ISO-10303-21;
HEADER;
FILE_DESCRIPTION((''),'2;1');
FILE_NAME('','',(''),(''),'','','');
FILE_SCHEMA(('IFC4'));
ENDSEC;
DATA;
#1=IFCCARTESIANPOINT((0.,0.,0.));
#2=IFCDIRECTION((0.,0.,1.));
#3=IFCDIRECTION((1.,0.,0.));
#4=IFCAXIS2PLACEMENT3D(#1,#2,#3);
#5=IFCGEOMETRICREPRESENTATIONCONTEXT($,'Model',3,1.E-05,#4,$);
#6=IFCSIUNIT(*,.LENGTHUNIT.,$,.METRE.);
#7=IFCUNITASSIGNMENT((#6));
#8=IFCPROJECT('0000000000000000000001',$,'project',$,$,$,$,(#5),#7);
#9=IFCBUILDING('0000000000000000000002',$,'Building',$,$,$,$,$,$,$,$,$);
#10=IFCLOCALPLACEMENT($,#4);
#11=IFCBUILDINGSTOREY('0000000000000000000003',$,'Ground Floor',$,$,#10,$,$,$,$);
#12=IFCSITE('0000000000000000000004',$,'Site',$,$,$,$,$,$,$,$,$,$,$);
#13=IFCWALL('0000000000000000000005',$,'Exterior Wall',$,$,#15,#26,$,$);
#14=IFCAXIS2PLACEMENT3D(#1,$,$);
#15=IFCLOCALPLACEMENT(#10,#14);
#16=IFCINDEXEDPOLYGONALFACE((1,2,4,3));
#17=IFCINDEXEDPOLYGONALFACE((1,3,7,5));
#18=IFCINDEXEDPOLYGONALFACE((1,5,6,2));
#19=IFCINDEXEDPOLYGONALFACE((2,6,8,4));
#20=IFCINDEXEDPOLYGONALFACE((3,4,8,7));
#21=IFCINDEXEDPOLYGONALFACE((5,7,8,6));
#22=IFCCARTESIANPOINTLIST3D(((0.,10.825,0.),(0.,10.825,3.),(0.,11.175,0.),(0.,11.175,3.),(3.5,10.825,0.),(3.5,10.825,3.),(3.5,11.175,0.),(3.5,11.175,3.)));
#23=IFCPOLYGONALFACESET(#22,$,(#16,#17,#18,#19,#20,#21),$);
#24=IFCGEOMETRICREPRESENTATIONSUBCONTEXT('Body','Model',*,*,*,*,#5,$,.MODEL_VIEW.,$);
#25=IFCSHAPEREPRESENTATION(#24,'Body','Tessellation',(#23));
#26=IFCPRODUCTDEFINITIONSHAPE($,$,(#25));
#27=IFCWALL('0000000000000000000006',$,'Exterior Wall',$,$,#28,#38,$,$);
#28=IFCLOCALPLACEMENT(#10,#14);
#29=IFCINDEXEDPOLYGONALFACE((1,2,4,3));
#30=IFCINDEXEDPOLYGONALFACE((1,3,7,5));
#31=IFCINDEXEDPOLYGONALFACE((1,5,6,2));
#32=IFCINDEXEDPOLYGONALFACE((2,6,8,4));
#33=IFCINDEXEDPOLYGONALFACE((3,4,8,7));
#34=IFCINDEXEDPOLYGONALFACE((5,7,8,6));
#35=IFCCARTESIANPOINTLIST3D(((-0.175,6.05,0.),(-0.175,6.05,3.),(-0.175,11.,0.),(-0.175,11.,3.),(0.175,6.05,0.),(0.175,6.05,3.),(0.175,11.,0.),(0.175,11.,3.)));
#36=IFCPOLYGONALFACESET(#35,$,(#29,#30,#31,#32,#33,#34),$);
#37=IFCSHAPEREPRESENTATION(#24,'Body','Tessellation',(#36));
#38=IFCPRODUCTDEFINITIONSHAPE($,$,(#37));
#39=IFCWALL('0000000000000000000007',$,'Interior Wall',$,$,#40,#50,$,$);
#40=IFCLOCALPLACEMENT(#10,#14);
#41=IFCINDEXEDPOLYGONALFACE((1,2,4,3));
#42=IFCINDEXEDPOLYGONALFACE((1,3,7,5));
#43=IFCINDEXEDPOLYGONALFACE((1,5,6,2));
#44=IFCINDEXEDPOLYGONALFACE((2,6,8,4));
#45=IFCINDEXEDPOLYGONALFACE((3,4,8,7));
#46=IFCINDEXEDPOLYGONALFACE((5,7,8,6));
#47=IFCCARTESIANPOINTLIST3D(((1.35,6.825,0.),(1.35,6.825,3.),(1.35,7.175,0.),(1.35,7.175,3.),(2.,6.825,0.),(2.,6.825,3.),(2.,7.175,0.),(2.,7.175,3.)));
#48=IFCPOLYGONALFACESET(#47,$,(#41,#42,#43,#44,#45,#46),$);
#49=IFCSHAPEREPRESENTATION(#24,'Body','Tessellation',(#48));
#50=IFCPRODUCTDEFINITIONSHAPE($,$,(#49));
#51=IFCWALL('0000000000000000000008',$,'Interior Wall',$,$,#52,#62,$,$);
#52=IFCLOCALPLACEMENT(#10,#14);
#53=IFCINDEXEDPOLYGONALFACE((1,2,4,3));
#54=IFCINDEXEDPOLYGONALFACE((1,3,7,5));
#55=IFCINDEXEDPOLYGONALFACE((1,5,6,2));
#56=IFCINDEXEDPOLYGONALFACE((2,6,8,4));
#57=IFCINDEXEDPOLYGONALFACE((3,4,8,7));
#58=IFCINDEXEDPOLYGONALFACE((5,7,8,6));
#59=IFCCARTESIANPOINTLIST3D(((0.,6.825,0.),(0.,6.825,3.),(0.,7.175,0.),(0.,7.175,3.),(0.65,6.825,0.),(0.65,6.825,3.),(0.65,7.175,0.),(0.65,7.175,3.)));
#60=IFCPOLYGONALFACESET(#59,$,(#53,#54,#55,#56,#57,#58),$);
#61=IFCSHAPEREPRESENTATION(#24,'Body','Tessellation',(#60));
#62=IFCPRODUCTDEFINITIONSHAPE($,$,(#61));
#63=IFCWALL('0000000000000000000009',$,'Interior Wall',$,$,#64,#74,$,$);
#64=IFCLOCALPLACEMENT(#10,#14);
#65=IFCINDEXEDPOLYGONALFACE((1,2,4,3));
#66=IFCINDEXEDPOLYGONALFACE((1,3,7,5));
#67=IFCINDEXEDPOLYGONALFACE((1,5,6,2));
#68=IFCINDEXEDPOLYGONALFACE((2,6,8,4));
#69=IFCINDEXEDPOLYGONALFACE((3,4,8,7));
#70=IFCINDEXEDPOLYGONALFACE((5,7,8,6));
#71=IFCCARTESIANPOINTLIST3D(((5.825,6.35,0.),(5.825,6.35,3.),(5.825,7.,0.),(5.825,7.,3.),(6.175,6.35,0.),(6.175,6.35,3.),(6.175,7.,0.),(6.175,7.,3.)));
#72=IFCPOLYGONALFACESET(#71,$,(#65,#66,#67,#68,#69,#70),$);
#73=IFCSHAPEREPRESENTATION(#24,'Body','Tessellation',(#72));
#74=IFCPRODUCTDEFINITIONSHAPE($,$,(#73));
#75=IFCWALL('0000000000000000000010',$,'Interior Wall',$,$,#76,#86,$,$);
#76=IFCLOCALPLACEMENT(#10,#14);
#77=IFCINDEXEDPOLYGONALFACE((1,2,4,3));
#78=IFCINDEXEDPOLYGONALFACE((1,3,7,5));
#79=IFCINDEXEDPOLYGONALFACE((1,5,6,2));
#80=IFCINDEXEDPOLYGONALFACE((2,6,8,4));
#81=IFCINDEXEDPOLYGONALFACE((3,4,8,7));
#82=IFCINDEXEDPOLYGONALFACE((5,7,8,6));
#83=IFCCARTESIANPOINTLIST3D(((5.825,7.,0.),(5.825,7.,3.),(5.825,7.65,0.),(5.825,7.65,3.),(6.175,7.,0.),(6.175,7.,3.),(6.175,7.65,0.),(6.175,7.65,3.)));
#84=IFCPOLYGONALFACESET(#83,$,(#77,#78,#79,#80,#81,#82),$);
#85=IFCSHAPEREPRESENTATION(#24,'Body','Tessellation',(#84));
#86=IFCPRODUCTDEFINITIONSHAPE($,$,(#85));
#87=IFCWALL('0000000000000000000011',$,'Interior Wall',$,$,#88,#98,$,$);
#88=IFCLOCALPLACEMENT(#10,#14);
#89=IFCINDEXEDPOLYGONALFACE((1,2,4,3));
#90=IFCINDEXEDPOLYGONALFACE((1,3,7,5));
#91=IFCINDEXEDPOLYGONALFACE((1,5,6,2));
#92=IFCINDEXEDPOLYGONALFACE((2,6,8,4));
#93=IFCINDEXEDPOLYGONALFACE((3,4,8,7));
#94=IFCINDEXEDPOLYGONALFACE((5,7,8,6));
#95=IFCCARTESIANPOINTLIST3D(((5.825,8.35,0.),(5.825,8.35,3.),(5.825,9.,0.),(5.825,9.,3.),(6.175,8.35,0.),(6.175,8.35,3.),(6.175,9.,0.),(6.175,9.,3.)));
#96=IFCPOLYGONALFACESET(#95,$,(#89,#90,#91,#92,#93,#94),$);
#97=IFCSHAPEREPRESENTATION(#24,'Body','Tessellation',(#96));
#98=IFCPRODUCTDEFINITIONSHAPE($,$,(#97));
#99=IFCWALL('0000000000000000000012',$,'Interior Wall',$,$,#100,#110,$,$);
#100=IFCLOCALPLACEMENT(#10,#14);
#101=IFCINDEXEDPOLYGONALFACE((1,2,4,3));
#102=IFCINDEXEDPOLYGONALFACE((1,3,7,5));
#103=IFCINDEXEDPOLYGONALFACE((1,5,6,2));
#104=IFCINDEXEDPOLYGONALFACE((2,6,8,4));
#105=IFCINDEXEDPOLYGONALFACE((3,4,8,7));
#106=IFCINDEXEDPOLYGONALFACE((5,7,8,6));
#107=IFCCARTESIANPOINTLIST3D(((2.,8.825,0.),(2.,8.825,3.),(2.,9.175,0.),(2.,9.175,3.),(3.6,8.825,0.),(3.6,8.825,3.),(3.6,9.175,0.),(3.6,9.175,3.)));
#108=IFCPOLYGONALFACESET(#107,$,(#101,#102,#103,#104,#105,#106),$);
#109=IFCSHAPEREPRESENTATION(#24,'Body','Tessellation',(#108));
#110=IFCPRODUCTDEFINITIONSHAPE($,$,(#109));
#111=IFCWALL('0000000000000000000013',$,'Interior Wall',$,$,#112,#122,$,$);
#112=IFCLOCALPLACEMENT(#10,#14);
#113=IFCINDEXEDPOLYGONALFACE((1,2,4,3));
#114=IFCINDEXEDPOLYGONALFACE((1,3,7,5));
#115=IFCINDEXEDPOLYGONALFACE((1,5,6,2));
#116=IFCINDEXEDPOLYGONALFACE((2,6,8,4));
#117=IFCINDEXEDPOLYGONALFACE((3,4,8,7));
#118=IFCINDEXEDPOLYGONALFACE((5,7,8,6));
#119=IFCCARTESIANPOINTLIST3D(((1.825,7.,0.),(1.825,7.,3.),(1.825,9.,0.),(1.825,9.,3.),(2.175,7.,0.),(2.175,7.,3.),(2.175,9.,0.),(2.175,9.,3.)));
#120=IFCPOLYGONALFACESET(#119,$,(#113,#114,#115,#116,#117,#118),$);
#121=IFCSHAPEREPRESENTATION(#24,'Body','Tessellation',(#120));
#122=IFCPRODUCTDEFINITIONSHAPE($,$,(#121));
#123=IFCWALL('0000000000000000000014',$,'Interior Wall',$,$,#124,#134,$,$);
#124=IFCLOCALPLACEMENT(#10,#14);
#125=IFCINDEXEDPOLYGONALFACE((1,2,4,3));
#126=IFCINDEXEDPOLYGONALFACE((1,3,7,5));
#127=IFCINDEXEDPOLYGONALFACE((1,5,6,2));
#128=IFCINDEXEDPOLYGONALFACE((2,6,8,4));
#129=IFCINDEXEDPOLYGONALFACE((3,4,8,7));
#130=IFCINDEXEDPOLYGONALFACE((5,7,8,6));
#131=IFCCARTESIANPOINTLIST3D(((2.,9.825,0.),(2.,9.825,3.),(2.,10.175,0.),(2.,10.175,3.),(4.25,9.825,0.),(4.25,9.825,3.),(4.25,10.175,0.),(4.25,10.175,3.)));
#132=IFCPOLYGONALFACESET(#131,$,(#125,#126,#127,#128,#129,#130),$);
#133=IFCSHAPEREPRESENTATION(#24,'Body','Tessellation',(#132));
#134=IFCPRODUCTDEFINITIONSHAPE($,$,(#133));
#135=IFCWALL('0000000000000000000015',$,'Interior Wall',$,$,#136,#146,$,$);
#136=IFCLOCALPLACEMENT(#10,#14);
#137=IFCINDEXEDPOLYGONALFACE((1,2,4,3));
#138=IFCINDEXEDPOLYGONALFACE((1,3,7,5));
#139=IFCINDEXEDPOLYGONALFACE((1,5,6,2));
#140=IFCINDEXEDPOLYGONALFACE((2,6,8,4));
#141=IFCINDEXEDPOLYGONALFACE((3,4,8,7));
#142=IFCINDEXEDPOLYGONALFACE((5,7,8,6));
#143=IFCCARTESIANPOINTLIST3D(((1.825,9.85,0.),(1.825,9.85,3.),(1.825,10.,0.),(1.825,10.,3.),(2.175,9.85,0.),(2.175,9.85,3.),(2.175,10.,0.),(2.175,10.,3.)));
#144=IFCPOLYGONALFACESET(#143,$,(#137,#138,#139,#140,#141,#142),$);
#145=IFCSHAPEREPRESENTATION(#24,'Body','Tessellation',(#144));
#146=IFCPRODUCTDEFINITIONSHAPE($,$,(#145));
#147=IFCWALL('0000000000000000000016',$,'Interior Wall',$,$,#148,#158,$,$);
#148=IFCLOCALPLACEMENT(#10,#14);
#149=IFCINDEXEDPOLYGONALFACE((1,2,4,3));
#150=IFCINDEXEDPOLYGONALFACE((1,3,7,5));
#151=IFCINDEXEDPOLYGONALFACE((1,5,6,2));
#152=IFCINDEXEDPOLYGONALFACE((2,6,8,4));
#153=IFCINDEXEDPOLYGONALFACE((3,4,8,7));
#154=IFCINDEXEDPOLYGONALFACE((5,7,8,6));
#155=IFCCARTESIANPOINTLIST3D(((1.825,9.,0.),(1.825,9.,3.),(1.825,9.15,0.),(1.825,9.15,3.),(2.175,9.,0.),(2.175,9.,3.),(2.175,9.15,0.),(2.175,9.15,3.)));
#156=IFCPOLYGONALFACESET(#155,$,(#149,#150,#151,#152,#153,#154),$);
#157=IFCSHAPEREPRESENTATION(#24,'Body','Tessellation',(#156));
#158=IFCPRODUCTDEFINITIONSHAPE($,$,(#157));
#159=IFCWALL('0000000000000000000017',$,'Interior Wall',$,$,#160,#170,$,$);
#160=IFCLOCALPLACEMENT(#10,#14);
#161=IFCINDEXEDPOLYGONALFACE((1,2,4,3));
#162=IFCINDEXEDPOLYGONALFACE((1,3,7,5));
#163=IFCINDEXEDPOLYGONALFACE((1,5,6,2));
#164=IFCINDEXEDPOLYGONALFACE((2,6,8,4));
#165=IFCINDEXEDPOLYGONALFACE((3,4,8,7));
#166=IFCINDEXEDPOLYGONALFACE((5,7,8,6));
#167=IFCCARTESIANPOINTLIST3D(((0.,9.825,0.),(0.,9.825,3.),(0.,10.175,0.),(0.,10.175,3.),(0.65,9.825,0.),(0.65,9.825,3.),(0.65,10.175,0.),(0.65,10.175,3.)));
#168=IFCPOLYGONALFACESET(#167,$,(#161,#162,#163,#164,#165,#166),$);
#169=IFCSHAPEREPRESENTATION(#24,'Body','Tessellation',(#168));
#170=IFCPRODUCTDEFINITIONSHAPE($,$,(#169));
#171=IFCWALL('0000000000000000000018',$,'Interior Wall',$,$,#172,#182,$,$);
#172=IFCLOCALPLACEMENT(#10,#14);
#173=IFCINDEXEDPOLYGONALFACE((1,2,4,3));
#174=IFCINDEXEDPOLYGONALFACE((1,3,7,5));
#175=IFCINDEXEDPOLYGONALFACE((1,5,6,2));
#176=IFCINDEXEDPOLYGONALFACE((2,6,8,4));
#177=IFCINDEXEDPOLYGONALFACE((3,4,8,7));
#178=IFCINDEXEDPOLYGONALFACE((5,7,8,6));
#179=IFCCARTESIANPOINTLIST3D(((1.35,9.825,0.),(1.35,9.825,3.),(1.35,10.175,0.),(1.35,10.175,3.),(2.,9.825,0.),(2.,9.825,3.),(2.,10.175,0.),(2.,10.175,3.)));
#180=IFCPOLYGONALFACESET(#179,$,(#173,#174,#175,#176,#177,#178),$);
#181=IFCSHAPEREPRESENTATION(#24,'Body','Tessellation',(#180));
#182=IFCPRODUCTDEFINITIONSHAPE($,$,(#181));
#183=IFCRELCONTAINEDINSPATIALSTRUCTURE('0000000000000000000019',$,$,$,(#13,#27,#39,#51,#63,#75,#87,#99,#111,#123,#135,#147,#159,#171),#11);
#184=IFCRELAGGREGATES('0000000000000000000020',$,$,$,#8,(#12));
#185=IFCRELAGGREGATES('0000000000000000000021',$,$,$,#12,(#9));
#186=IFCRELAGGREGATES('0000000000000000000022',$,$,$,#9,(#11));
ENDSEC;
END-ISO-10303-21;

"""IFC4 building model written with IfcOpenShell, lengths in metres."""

from ifc_helpers import new_model, si_unit, frame, origin_with_axes, place, context, subcontext, project, spatial, indexed_curve, outline, extrude, element, save


model = new_model("IFC4")

# Units and contexts
model_context = context("Model", 3, precision=1e-05, world=origin_with_axes())
body_context = subcontext(model_context, "Body", "Model", "MODEL_VIEW")
ifc_project = project(units=[si_unit("LENGTHUNIT", "METRE")], contexts=[model_context])

# Site, building, storey
site = spatial("IfcSite", under=ifc_project, Name="Site")
building = spatial("IfcBuilding", under=site, Name="Building")
storey_placement = place(None, origin_with_axes())
storey = spatial("IfcBuildingStorey", under=building, at=storey_placement, Name="Ground Floor")

# Walls
wall_1_placement = place(storey_placement, frame((3.5, 11.0, 0.0), z_axis=(0.0, 0.0, 1.0), x_axis=(-1.0, 0.0, 0.0)))
element("IfcWall", 1, at=wall_1_placement, inside=storey, Name="Exterior Wall", context=body_context, shape_type="SweptSolid", body=[
    extrude(outline(indexed_curve([(0.0, 0.0), (0.0, 0.35), (3.5, 0.35), (3.5, 0.0), (0.0, 0.0)], self_intersect=False)), frame((0.0, -0.175, 0.0), z_axis=(0.0, 0.0, 1.0), x_axis=(1.0, 0.0, 0.0)), (0.0, 0.0, 1.0), 3.0),
])
wall_2_placement = place(storey_placement, frame((0.0, 11.0, 0.0), z_axis=(0.0, 0.0, 1.0), x_axis=(0.0, -1.0, 0.0)))
element("IfcWall", 2, at=wall_2_placement, inside=storey, Name="Exterior Wall", context=body_context, shape_type="SweptSolid", body=[
    extrude(outline(indexed_curve([(0.0, 0.0), (0.0, 0.35), (4.95, 0.35), (4.95, 0.0), (0.0, 0.0)], self_intersect=False)), frame((0.0, -0.175, 0.0), z_axis=(0.0, 0.0, 1.0), x_axis=(1.0, 0.0, 0.0)), (0.0, 0.0, 1.0), 3.0),
])
for number, where, z_axis, x_axis, name in (
    (3, (2.0, 7.0, 0.0), (0.0, 0.0, 1.0), (-1.0, 0.0, 0.0), "Interior Wall"),
    (4, (0.65, 7.0, 0.0), (0.0, 0.0, 1.0), (-1.0, 0.0, 0.0), "Interior Wall"),
):
    element("IfcWall", number, at=place(storey_placement, frame(where, z_axis=z_axis, x_axis=x_axis)), inside=storey, Name=name, context=body_context, shape_type="SweptSolid", body=[
        extrude(outline(indexed_curve([(0.0, 0.0), (0.0, 0.35), (0.65, 0.35), (0.65, 0.0), (0.0, 0.0)], self_intersect=False)), frame((0.0, -0.175, 0.0), z_axis=(0.0, 0.0, 1.0), x_axis=(1.0, 0.0, 0.0)), (0.0, 0.0, 1.0), 3.0),
    ])
for number, where, z_axis, x_axis, name in (
    (5, (6.0, 6.35, 0.0), (0.0, 0.0, 1.0), (0.0, 1.0, 0.0), "Interior Wall"),
    (6, (6.0, 7.0, 0.0), (0.0, 0.0, 1.0), (0.0, 1.0, 0.0), "Interior Wall"),
    (7, (6.0, 8.35, 0.0), (0.0, 0.0, 1.0), (0.0, 1.0, 0.0), "Interior Wall"),
):
    element("IfcWall", number, at=place(storey_placement, frame(where, z_axis=z_axis, x_axis=x_axis)), inside=storey, Name=name, context=body_context, shape_type="SweptSolid", body=[
        extrude(outline(indexed_curve([(0.0, 0.0), (0.0, 0.35), (0.65, 0.35), (0.65, 0.0), (0.0, 0.0)], self_intersect=False)), frame((0.0, -0.175, 0.0), z_axis=(0.0, 0.0, 1.0), x_axis=(1.0, 0.0, 0.0)), (0.0, 0.0, 1.0), 3.0),
    ])
wall_3_placement = place(storey_placement, frame((3.6, 9.0, 0.0), z_axis=(0.0, 0.0, 1.0), x_axis=(-1.0, 0.0, 0.0)))
element("IfcWall", 8, at=wall_3_placement, inside=storey, Name="Interior Wall", context=body_context, shape_type="SweptSolid", body=[
    extrude(outline(indexed_curve([(0.0, 0.0), (0.0, 0.35), (1.6, 0.35), (1.6, 0.0), (0.0, 0.0)], self_intersect=False)), frame((0.0, -0.175, 0.0), z_axis=(0.0, 0.0, 1.0), x_axis=(1.0, 0.0, 0.0)), (0.0, 0.0, 1.0), 3.0),
])
wall_4_placement = place(storey_placement, frame((2.0, 9.0, 0.0), z_axis=(0.0, 0.0, 1.0), x_axis=(0.0, -1.0, 0.0)))
element("IfcWall", 9, at=wall_4_placement, inside=storey, Name="Interior Wall", context=body_context, shape_type="SweptSolid", body=[
    extrude(outline(indexed_curve([(0.0, 0.0), (0.0, 0.35), (2.0, 0.35), (2.0, 0.0), (0.0, 0.0)], self_intersect=False)), frame((0.0, -0.175, 0.0), z_axis=(0.0, 0.0, 1.0), x_axis=(1.0, 0.0, 0.0)), (0.0, 0.0, 1.0), 3.0),
])
wall_5_placement = place(storey_placement, frame((4.25, 10.0, 0.0), z_axis=(0.0, 0.0, 1.0), x_axis=(-1.0, 0.0, 0.0)))
element("IfcWall", 10, at=wall_5_placement, inside=storey, Name="Interior Wall", context=body_context, shape_type="SweptSolid", body=[
    extrude(outline(indexed_curve([(0.0, 0.0), (0.0, 0.35), (2.25, 0.35), (2.25, 0.0), (0.0, 0.0)], self_intersect=False)), frame((0.0, -0.175, 0.0), z_axis=(0.0, 0.0, 1.0), x_axis=(1.0, 0.0, 0.0)), (0.0, 0.0, 1.0), 3.0),
])
for number, where, z_axis, x_axis, name in (
    (11, (2.0, 10.0, 0.0), (0.0, 0.0, 1.0), (0.0, -1.0, 0.0), "Interior Wall"),
    (12, (2.0, 9.15, 0.0), (0.0, 0.0, 1.0), (0.0, -1.0, 0.0), "Interior Wall"),
):
    element("IfcWall", number, at=place(storey_placement, frame(where, z_axis=z_axis, x_axis=x_axis)), inside=storey, Name=name, context=body_context, shape_type="SweptSolid", body=[
        extrude(outline(indexed_curve([(0.0, 0.0), (0.0, 0.35), (0.15, 0.35), (0.15, 0.0), (0.0, 0.0)], self_intersect=False)), frame((0.0, -0.175, 0.0), z_axis=(0.0, 0.0, 1.0), x_axis=(1.0, 0.0, 0.0)), (0.0, 0.0, 1.0), 3.0),
    ])
wall_6_placement = place(storey_placement, frame((0.0, 10.0, 0.0), z_axis=(0.0, 0.0, 1.0), x_axis=(1.0, 0.0, 0.0)))
element("IfcWall", 13, at=wall_6_placement, inside=storey, Name="Interior Wall", context=body_context, shape_type="SweptSolid", body=[
    extrude(outline(indexed_curve([(0.0, 0.0), (0.0, 0.35), (0.65, 0.35), (0.65, 0.0), (0.0, 0.0)], self_intersect=False)), frame((0.0, -0.175, 0.0), z_axis=(0.0, 0.0, 1.0), x_axis=(1.0, 0.0, 0.0)), (0.0, 0.0, 1.0), 3.0),
])
wall_7_placement = place(storey_placement, frame((1.35, 10.0, 0.0), z_axis=(0.0, 0.0, 1.0), x_axis=(1.0, 0.0, 0.0)))
element("IfcWall", 14, at=wall_7_placement, inside=storey, Name="Interior Wall", context=body_context, shape_type="SweptSolid", body=[
    extrude(outline(indexed_curve([(0.0, 0.0), (0.0, 0.35), (0.65, 0.35), (0.65, 0.0), (0.0, 0.0)], self_intersect=False)), frame((0.0, -0.175, 0.0), z_axis=(0.0, 0.0, 1.0), x_axis=(1.0, 0.0, 0.0)), (0.0, 0.0, 1.0), 3.0),
])

save(model, "model.ifc")
